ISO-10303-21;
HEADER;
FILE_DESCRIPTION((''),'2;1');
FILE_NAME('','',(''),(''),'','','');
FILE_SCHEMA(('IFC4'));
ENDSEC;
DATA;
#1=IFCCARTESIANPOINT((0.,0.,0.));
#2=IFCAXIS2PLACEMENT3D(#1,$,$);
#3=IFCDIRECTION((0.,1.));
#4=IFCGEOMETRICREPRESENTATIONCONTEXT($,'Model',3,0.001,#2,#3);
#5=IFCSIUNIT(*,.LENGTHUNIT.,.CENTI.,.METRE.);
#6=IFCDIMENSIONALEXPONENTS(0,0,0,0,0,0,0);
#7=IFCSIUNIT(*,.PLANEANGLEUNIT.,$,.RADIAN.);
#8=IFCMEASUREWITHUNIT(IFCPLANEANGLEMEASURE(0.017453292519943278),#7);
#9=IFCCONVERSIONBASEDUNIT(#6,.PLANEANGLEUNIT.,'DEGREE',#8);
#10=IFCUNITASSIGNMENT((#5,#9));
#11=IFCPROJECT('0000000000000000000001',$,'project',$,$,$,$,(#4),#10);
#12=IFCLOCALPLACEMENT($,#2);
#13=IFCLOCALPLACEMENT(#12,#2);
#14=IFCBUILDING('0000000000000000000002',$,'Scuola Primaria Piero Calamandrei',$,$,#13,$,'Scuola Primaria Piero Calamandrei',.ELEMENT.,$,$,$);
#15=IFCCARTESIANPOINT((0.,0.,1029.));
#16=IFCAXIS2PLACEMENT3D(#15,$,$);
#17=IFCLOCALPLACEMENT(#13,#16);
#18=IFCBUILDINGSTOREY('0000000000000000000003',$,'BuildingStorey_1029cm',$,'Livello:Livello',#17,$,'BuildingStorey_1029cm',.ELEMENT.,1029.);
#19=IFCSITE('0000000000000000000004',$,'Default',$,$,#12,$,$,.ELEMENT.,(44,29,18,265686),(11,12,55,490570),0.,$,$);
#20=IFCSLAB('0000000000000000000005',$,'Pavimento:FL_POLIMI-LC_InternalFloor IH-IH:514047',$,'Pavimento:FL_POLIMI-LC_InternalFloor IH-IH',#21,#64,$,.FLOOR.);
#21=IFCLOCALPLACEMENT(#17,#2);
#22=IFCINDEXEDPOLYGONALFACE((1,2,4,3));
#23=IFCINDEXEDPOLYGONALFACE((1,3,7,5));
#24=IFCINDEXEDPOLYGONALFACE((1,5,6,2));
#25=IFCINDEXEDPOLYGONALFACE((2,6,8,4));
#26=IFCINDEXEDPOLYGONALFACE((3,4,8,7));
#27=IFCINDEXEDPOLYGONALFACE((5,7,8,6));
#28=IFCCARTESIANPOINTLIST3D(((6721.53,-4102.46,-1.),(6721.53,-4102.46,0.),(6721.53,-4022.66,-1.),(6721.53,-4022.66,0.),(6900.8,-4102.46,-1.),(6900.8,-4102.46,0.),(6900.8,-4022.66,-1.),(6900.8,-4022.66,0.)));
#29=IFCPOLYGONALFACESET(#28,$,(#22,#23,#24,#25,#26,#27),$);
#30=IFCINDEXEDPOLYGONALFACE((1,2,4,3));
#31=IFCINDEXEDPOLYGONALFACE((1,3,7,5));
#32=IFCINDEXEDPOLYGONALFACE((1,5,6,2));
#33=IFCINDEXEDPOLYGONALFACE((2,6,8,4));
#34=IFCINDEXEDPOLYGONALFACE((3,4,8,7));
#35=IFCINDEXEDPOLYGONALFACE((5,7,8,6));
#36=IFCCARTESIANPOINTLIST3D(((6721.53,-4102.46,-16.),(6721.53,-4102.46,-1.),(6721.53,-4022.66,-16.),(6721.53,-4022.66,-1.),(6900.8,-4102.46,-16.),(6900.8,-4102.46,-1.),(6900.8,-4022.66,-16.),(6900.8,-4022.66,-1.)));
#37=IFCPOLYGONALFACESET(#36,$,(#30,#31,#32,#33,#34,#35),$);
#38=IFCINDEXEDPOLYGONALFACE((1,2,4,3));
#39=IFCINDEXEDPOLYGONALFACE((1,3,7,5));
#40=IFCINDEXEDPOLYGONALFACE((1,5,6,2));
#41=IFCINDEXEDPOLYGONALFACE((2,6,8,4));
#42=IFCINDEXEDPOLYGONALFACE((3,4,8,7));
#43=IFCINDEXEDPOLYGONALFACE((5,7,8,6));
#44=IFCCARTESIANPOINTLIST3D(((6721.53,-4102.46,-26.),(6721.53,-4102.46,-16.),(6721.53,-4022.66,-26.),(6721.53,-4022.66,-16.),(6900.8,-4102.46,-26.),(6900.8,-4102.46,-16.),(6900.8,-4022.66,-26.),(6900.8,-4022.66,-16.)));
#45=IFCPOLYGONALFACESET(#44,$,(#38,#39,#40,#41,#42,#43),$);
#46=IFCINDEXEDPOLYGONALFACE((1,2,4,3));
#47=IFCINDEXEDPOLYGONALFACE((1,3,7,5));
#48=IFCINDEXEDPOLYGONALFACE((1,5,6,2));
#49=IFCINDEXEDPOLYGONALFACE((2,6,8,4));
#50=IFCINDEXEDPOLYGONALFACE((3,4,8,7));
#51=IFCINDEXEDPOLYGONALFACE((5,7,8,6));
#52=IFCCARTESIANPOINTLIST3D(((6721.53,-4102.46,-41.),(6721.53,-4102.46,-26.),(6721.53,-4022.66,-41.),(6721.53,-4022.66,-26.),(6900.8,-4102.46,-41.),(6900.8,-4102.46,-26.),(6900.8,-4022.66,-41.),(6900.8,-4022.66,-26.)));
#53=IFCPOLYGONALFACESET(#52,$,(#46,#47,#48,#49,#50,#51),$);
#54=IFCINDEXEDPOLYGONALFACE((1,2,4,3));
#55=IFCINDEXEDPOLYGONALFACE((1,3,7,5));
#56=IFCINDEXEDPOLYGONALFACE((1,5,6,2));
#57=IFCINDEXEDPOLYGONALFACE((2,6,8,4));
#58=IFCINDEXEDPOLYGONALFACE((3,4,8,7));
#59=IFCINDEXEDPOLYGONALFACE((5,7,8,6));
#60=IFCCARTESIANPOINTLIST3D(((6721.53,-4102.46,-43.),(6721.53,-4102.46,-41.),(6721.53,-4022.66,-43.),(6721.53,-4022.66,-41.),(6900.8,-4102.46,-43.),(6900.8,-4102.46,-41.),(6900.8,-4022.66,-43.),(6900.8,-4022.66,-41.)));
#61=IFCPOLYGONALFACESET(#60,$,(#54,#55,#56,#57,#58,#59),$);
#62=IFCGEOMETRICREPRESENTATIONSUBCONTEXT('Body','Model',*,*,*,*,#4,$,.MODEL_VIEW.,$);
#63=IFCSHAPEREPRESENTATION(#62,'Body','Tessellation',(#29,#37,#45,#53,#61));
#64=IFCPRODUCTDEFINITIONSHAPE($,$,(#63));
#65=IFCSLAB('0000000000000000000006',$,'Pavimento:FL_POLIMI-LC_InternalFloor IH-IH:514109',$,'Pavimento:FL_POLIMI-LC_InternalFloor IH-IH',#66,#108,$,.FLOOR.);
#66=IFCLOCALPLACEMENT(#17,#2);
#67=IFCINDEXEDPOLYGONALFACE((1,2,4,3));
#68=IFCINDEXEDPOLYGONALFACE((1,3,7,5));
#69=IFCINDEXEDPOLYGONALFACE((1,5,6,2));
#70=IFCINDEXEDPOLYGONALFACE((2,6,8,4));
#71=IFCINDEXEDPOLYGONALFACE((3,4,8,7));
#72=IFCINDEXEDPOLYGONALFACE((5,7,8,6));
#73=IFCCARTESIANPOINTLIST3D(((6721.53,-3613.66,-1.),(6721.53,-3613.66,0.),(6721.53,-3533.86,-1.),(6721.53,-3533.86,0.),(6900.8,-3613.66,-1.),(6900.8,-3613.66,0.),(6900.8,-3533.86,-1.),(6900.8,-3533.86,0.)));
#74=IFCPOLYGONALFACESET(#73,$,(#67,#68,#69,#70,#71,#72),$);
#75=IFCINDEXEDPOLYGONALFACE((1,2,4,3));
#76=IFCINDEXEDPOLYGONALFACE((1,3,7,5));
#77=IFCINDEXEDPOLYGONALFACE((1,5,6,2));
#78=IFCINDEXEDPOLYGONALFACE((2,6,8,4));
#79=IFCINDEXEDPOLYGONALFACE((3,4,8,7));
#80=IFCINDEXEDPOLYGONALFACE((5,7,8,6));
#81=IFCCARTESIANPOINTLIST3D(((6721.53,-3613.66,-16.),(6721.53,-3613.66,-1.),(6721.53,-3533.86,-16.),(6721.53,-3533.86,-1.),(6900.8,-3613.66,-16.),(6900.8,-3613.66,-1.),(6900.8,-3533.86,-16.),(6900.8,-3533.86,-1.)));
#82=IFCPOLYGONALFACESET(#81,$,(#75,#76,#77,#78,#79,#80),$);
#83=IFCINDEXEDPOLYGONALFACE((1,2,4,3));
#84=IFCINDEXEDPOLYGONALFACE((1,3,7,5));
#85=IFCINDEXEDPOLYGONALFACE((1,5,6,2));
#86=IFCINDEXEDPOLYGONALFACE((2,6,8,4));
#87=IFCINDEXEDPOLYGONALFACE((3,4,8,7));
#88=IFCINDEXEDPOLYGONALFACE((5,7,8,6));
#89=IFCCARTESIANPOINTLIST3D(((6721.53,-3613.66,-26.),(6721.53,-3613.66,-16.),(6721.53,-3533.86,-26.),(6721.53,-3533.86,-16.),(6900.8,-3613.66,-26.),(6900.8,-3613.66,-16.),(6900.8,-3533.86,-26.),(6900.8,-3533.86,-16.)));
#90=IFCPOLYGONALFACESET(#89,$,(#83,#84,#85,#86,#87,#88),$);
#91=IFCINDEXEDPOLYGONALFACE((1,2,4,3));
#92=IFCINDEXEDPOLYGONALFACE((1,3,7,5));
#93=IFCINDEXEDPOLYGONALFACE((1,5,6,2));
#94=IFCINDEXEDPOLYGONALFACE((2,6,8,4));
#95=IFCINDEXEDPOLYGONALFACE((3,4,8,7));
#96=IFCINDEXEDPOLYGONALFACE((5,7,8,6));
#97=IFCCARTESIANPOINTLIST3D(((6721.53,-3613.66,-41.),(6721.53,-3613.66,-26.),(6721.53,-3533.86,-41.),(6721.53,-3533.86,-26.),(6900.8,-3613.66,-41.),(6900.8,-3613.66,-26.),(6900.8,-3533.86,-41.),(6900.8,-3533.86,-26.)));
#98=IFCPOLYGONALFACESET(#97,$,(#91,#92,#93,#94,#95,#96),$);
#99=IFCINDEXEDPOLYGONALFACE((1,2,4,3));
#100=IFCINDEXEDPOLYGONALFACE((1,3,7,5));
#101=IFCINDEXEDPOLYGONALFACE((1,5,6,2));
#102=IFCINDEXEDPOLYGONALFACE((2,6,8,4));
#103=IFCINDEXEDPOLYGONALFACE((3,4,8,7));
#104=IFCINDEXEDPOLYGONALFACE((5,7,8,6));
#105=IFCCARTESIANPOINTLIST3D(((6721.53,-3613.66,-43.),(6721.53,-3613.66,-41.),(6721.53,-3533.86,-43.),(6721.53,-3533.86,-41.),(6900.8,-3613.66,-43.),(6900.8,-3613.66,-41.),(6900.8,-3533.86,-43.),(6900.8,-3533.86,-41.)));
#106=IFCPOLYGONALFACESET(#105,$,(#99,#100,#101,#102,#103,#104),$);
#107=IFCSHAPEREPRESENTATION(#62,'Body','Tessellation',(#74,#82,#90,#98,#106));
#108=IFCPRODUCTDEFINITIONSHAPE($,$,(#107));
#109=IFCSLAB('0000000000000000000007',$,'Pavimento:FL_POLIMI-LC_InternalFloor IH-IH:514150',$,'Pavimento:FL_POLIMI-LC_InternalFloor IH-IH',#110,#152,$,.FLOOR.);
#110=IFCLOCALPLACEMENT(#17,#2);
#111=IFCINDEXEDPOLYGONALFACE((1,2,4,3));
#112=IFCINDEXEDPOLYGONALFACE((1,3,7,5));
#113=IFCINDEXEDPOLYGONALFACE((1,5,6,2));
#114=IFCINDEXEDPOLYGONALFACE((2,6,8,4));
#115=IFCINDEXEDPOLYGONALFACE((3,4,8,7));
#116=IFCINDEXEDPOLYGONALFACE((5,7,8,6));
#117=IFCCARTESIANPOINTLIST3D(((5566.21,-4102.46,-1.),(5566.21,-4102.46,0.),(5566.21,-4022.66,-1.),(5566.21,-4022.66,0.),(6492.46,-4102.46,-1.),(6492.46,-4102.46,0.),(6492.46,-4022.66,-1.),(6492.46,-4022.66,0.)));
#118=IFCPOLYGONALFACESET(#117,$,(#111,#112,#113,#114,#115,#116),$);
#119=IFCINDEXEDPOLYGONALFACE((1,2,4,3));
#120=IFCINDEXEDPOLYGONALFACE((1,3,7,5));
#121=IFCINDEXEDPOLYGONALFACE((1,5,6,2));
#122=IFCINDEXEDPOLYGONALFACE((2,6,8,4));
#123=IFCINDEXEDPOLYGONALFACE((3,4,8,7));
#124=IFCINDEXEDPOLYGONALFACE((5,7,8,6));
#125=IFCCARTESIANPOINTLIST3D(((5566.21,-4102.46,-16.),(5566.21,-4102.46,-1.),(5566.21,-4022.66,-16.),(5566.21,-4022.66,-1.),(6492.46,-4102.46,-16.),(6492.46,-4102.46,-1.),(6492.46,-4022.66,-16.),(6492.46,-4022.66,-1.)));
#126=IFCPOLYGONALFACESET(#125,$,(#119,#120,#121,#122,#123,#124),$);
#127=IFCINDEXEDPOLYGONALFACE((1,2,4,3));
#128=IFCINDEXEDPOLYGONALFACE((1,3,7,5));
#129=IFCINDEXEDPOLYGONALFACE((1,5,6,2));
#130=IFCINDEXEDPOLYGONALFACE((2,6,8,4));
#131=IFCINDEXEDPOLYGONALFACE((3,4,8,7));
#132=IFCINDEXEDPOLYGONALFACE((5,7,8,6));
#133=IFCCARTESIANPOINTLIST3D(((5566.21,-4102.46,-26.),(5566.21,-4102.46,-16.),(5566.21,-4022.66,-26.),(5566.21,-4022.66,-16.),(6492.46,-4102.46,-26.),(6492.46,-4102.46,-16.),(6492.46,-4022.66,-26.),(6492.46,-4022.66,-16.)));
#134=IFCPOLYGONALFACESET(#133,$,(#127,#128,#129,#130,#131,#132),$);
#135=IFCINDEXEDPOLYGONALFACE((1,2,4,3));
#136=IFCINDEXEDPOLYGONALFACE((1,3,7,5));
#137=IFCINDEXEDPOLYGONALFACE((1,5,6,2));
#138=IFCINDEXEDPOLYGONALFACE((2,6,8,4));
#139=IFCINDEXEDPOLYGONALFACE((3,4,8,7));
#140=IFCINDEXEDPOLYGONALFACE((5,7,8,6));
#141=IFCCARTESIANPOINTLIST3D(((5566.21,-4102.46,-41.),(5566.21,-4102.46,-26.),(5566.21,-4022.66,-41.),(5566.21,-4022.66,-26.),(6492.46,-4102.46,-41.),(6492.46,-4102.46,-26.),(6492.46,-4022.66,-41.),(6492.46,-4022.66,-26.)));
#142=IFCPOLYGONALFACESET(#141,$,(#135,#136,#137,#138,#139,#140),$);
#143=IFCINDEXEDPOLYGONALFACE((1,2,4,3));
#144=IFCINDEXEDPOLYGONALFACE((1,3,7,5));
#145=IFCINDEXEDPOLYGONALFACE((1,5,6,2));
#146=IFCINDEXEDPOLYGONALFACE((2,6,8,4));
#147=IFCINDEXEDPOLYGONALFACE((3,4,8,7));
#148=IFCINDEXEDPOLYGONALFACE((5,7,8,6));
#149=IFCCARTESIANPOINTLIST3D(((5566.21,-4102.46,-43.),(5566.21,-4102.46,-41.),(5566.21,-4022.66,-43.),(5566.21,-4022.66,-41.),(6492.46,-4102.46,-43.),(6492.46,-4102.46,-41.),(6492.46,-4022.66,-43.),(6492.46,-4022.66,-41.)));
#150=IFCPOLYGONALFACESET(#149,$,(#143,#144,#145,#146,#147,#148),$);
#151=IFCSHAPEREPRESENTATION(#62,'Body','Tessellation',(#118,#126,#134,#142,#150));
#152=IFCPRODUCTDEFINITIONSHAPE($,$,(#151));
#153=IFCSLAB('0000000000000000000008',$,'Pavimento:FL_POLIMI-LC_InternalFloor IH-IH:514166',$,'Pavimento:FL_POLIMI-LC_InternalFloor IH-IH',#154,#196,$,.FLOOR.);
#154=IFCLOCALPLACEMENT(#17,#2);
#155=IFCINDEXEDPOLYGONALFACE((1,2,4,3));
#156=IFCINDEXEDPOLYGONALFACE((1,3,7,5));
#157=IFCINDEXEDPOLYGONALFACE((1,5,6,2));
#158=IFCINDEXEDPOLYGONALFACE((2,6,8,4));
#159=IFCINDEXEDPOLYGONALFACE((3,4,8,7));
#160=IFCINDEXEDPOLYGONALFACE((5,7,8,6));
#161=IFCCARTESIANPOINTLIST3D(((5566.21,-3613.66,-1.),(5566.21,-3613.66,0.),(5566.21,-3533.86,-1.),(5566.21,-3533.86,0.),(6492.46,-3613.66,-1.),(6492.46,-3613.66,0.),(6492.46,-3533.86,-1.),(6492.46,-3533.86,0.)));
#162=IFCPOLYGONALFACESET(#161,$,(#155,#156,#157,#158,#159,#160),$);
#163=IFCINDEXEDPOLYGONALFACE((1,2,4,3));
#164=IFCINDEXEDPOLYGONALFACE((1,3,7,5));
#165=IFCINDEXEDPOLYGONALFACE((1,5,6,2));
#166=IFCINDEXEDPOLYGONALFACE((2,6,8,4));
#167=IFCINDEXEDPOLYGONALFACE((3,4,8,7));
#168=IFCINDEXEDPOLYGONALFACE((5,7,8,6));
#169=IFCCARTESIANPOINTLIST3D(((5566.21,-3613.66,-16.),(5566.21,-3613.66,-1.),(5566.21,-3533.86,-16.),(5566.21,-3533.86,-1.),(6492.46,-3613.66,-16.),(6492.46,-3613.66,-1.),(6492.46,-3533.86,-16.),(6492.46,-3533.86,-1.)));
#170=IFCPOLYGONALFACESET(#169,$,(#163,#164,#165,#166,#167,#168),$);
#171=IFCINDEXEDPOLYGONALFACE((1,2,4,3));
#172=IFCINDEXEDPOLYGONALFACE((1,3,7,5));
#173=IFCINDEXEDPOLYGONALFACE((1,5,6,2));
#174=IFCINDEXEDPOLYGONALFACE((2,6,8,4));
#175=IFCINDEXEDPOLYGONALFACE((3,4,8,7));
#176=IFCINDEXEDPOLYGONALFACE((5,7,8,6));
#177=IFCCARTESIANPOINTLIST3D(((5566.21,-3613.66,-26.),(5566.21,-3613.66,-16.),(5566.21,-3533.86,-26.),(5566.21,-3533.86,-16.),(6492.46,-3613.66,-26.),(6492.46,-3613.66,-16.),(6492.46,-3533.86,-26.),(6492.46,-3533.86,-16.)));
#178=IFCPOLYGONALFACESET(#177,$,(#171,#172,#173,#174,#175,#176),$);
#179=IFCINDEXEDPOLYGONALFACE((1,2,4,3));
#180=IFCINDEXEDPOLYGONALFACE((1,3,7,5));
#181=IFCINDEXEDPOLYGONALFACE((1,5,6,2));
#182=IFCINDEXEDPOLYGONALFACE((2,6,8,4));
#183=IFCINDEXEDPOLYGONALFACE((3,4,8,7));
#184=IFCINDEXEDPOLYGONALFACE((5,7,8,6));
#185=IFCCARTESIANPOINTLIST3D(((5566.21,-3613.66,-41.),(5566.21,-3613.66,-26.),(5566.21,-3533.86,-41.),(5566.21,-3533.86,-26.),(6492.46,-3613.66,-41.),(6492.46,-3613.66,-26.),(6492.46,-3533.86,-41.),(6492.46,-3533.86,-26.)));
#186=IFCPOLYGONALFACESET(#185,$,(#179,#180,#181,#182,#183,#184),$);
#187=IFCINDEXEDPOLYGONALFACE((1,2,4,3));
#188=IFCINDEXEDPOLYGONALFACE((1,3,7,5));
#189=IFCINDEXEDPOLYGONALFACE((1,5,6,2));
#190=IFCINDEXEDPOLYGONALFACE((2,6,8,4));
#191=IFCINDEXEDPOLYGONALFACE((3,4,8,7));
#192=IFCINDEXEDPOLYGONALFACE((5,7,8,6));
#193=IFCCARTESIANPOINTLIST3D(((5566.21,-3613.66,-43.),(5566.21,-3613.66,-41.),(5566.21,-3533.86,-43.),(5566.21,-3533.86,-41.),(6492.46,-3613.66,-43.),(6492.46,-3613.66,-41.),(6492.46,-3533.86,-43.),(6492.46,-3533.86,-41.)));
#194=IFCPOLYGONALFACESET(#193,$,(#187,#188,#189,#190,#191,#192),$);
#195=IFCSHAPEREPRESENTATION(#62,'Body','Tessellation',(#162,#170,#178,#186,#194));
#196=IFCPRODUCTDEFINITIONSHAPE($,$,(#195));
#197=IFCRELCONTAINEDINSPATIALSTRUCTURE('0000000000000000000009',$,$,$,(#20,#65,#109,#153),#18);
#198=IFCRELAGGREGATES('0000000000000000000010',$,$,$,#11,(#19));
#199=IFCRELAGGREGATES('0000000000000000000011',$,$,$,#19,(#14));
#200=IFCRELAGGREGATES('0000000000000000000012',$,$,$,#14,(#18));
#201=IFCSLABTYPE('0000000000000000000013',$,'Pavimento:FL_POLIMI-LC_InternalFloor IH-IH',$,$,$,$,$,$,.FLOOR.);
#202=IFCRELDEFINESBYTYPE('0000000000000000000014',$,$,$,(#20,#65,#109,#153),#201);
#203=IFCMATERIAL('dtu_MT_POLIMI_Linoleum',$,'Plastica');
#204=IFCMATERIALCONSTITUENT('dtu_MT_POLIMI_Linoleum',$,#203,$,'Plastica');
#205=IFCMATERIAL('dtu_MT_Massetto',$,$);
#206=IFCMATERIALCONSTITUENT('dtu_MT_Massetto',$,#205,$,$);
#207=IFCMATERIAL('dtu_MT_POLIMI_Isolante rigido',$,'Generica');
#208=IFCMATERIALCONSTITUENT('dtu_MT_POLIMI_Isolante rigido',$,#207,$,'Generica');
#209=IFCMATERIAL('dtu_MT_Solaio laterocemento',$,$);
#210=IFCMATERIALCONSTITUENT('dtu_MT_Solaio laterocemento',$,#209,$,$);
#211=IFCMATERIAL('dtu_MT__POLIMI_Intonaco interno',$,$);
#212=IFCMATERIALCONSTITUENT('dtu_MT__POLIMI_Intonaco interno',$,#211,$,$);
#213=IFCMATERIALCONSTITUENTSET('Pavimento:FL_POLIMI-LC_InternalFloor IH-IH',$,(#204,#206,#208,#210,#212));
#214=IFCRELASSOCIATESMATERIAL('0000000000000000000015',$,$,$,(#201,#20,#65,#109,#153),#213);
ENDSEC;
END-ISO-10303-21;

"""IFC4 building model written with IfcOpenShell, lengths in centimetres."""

from ifc_helpers import new_model, entity, si_unit, converted_unit, direction, frame, origin, place, context, subcontext, project, spatial, indexed_curve, outline, extrude, material, constituent, constituent_set, type_object, element, save


model = new_model("IFC4")

# Units and contexts
model_context = context("Model", 3, precision=0.001, world=origin(), true_north=direction((0.0, 1.0)))
body_context = subcontext(model_context, "Body", "Model", "MODEL_VIEW")
ifc_project = project(units=[si_unit("LENGTHUNIT", "METRE", prefix="CENTI"), converted_unit("PLANEANGLEUNIT", "DEGREE", entity("IfcPlaneAngleMeasure", 0.017453292519943278), si_unit("PLANEANGLEUNIT", "RADIAN"), dimensions=[0, 0, 0, 0, 0, 0, 0])], contexts=[model_context])

# Site, building, storey
site_placement = place(None, origin())
site = spatial("IfcSite", under=ifc_project, at=site_placement, Name="Default", CompositionType="ELEMENT", RefLatitude=(44, 29, 18, 265686), RefLongitude=(11, 12, 55, 490570), RefElevation=0.0)
building_placement = place(site_placement, origin())
building = spatial("IfcBuilding", under=site, at=building_placement, Name="Scuola Primaria Piero Calamandrei", LongName="Scuola Primaria Piero Calamandrei", CompositionType="ELEMENT")
storey_placement = place(building_placement, frame((0.0, 0.0, 1029.0)))
storey = spatial("IfcBuildingStorey", under=building, at=storey_placement, Name="BuildingStorey_1029cm", ObjectType="Livello:Livello", LongName="BuildingStorey_1029cm", CompositionType="ELEMENT", Elevation=1029.0)

# Slabs
ifc_material_1 = material(Name="dtu_MT_POLIMI_Linoleum", Category="Plastica")
ifc_constituent_1 = constituent(ifc_material_1, Name="dtu_MT_POLIMI_Linoleum", Category="Plastica")
ifc_material_2 = material(Name="dtu_MT_Massetto")
ifc_constituent_2 = constituent(ifc_material_2, Name="dtu_MT_Massetto")
ifc_material_3 = material(Name="dtu_MT_POLIMI_Isolante rigido", Category="Generica")
ifc_constituent_3 = constituent(ifc_material_3, Name="dtu_MT_POLIMI_Isolante rigido", Category="Generica")
ifc_material_4 = material(Name="dtu_MT_Solaio laterocemento")
ifc_constituent_4 = constituent(ifc_material_4, Name="dtu_MT_Solaio laterocemento")
ifc_material_5 = material(Name="dtu_MT__POLIMI_Intonaco interno")
ifc_constituent_5 = constituent(ifc_material_5, Name="dtu_MT__POLIMI_Intonaco interno")
ifc_constituent_set_1 = constituent_set(constituents=[ifc_constituent_1, ifc_constituent_2, ifc_constituent_3, ifc_constituent_4, ifc_constituent_5], Name="Pavimento:FL_POLIMI-LC_InternalFloor IH-IH")
slab_type_1 = type_object("IfcSlabType", Name="Pavimento:FL_POLIMI-LC_InternalFloor IH-IH", PredefinedType="FLOOR", material=ifc_constituent_set_1)
slab_1_placement = place(storey_placement, origin())
element("IfcSlab", 1, at=slab_1_placement, inside=storey, type_object=slab_type_1, material=ifc_constituent_set_1, Name="Pavimento:FL_POLIMI-LC_InternalFloor IH-IH:514047", ObjectType="Pavimento:FL_POLIMI-LC_InternalFloor IH-IH", PredefinedType="FLOOR", context=body_context, shape_type="SweptSolid", body=[
    extrude(outline(indexed_curve([(-39.9, -89.64), (39.9, -89.64), (39.9, 89.64), (-39.9, 89.64), (-39.9, -89.64)], self_intersect=False)), frame((6811.16, -4062.56, -1.0), z_axis=(0.0, 0.0, 1.0), x_axis=(0.0, 1.0, 0.0)), (0.0, 0.0, 1.0), 1.0),
    extrude(outline(indexed_curve([(-39.9, -89.64), (39.9, -89.64), (39.9, 89.64), (-39.9, 89.64), (-39.9, -89.64)], self_intersect=False)), frame((6811.16, -4062.56, -16.0), z_axis=(0.0, 0.0, 1.0), x_axis=(0.0, 1.0, 0.0)), (0.0, 0.0, 1.0), 15.0),
    extrude(outline(indexed_curve([(-39.9, -89.64), (39.9, -89.64), (39.9, 89.64), (-39.9, 89.64), (-39.9, -89.64)], self_intersect=False)), frame((6811.16, -4062.56, -26.0), z_axis=(0.0, 0.0, 1.0), x_axis=(0.0, 1.0, 0.0)), (0.0, 0.0, 1.0), 10.0),
    extrude(outline(indexed_curve([(-39.9, -89.64), (39.9, -89.64), (39.9, 89.64), (-39.9, 89.64), (-39.9, -89.64)], self_intersect=False)), frame((6811.16, -4062.56, -41.0), z_axis=(0.0, 0.0, 1.0), x_axis=(0.0, 1.0, 0.0)), (0.0, 0.0, 1.0), 15.0),
    extrude(outline(indexed_curve([(-39.9, -89.64), (39.9, -89.64), (39.9, 89.64), (-39.9, 89.64), (-39.9, -89.64)], self_intersect=False)), frame((6811.16, -4062.56, -43.0), z_axis=(0.0, 0.0, 1.0), x_axis=(0.0, 1.0, 0.0)), (0.0, 0.0, 1.0), 2.0),
])
slab_2_placement = place(storey_placement, origin())
element("IfcSlab", 2, at=slab_2_placement, inside=storey, type_object=slab_type_1, material=ifc_constituent_set_1, Name="Pavimento:FL_POLIMI-LC_InternalFloor IH-IH:514109", ObjectType="Pavimento:FL_POLIMI-LC_InternalFloor IH-IH", PredefinedType="FLOOR", context=body_context, shape_type="SweptSolid", body=[
    extrude(outline(indexed_curve([(-89.64, -39.9), (89.64, -39.9), (89.64, 39.9), (-89.64, 39.9), (-89.64, -39.9)], self_intersect=False)), frame((6811.16, -3573.76, -1.0)), (0.0, 0.0, 1.0), 1.0),
    extrude(outline(indexed_curve([(-89.64, -39.9), (89.64, -39.9), (89.64, 39.9), (-89.64, 39.9), (-89.64, -39.9)], self_intersect=False)), frame((6811.16, -3573.76, -16.0)), (0.0, 0.0, 1.0), 15.0),
    extrude(outline(indexed_curve([(-89.64, -39.9), (89.64, -39.9), (89.64, 39.9), (-89.64, 39.9), (-89.64, -39.9)], self_intersect=False)), frame((6811.16, -3573.76, -26.0)), (0.0, 0.0, 1.0), 10.0),
    extrude(outline(indexed_curve([(-89.64, -39.9), (89.64, -39.9), (89.64, 39.9), (-89.64, 39.9), (-89.64, -39.9)], self_intersect=False)), frame((6811.16, -3573.76, -41.0)), (0.0, 0.0, 1.0), 15.0),
    extrude(outline(indexed_curve([(-89.64, -39.9), (89.64, -39.9), (89.64, 39.9), (-89.64, 39.9), (-89.64, -39.9)], self_intersect=False)), frame((6811.16, -3573.76, -43.0)), (0.0, 0.0, 1.0), 2.0),
])
slab_3_placement = place(storey_placement, origin())
element("IfcSlab", 3, at=slab_3_placement, inside=storey, type_object=slab_type_1, material=ifc_constituent_set_1, Name="Pavimento:FL_POLIMI-LC_InternalFloor IH-IH:514150", ObjectType="Pavimento:FL_POLIMI-LC_InternalFloor IH-IH", PredefinedType="FLOOR", context=body_context, shape_type="SweptSolid", body=[
    extrude(outline(indexed_curve([(-463.12, -39.9), (463.12, -39.9), (463.12, 39.9), (-463.12, 39.9), (-463.12, -39.9)], self_intersect=False)), frame((6029.33, -4062.56, -1.0)), (0.0, 0.0, 1.0), 1.0),
    extrude(outline(indexed_curve([(-463.12, -39.9), (463.12, -39.9), (463.12, 39.9), (-463.12, 39.9), (-463.12, -39.9)], self_intersect=False)), frame((6029.33, -4062.56, -16.0)), (0.0, 0.0, 1.0), 15.0),
    extrude(outline(indexed_curve([(-463.12, -39.9), (463.12, -39.9), (463.12, 39.9), (-463.12, 39.9), (-463.12, -39.9)], self_intersect=False)), frame((6029.33, -4062.56, -26.0)), (0.0, 0.0, 1.0), 10.0),
    extrude(outline(indexed_curve([(-463.12, -39.9), (463.12, -39.9), (463.12, 39.9), (-463.12, 39.9), (-463.12, -39.9)], self_intersect=False)), frame((6029.33, -4062.56, -41.0)), (0.0, 0.0, 1.0), 15.0),
    extrude(outline(indexed_curve([(-463.12, -39.9), (463.12, -39.9), (463.12, 39.9), (-463.12, 39.9), (-463.12, -39.9)], self_intersect=False)), frame((6029.33, -4062.56, -43.0)), (0.0, 0.0, 1.0), 2.0),
])
slab_4_placement = place(storey_placement, origin())
element("IfcSlab", 4, at=slab_4_placement, inside=storey, type_object=slab_type_1, material=ifc_constituent_set_1, Name="Pavimento:FL_POLIMI-LC_InternalFloor IH-IH:514166", ObjectType="Pavimento:FL_POLIMI-LC_InternalFloor IH-IH", PredefinedType="FLOOR", context=body_context, shape_type="SweptSolid", body=[
    extrude(outline(indexed_curve([(-463.12, -39.9), (463.12, -39.9), (463.12, 39.9), (-463.12, 39.9), (-463.12, -39.9)], self_intersect=False)), frame((6029.33, -3573.76, -1.0)), (0.0, 0.0, 1.0), 1.0),
    extrude(outline(indexed_curve([(-463.12, -39.9), (463.12, -39.9), (463.12, 39.9), (-463.12, 39.9), (-463.12, -39.9)], self_intersect=False)), frame((6029.33, -3573.76, -16.0)), (0.0, 0.0, 1.0), 15.0),
    extrude(outline(indexed_curve([(-463.12, -39.9), (463.12, -39.9), (463.12, 39.9), (-463.12, 39.9), (-463.12, -39.9)], self_intersect=False)), frame((6029.33, -3573.76, -26.0)), (0.0, 0.0, 1.0), 10.0),
    extrude(outline(indexed_curve([(-463.12, -39.9), (463.12, -39.9), (463.12, 39.9), (-463.12, 39.9), (-463.12, -39.9)], self_intersect=False)), frame((6029.33, -3573.76, -41.0)), (0.0, 0.0, 1.0), 15.0),
    extrude(outline(indexed_curve([(-463.12, -39.9), (463.12, -39.9), (463.12, 39.9), (-463.12, 39.9), (-463.12, -39.9)], self_intersect=False)), frame((6029.33, -3573.76, -43.0)), (0.0, 0.0, 1.0), 2.0),
])

save(model, "model.ifc")
